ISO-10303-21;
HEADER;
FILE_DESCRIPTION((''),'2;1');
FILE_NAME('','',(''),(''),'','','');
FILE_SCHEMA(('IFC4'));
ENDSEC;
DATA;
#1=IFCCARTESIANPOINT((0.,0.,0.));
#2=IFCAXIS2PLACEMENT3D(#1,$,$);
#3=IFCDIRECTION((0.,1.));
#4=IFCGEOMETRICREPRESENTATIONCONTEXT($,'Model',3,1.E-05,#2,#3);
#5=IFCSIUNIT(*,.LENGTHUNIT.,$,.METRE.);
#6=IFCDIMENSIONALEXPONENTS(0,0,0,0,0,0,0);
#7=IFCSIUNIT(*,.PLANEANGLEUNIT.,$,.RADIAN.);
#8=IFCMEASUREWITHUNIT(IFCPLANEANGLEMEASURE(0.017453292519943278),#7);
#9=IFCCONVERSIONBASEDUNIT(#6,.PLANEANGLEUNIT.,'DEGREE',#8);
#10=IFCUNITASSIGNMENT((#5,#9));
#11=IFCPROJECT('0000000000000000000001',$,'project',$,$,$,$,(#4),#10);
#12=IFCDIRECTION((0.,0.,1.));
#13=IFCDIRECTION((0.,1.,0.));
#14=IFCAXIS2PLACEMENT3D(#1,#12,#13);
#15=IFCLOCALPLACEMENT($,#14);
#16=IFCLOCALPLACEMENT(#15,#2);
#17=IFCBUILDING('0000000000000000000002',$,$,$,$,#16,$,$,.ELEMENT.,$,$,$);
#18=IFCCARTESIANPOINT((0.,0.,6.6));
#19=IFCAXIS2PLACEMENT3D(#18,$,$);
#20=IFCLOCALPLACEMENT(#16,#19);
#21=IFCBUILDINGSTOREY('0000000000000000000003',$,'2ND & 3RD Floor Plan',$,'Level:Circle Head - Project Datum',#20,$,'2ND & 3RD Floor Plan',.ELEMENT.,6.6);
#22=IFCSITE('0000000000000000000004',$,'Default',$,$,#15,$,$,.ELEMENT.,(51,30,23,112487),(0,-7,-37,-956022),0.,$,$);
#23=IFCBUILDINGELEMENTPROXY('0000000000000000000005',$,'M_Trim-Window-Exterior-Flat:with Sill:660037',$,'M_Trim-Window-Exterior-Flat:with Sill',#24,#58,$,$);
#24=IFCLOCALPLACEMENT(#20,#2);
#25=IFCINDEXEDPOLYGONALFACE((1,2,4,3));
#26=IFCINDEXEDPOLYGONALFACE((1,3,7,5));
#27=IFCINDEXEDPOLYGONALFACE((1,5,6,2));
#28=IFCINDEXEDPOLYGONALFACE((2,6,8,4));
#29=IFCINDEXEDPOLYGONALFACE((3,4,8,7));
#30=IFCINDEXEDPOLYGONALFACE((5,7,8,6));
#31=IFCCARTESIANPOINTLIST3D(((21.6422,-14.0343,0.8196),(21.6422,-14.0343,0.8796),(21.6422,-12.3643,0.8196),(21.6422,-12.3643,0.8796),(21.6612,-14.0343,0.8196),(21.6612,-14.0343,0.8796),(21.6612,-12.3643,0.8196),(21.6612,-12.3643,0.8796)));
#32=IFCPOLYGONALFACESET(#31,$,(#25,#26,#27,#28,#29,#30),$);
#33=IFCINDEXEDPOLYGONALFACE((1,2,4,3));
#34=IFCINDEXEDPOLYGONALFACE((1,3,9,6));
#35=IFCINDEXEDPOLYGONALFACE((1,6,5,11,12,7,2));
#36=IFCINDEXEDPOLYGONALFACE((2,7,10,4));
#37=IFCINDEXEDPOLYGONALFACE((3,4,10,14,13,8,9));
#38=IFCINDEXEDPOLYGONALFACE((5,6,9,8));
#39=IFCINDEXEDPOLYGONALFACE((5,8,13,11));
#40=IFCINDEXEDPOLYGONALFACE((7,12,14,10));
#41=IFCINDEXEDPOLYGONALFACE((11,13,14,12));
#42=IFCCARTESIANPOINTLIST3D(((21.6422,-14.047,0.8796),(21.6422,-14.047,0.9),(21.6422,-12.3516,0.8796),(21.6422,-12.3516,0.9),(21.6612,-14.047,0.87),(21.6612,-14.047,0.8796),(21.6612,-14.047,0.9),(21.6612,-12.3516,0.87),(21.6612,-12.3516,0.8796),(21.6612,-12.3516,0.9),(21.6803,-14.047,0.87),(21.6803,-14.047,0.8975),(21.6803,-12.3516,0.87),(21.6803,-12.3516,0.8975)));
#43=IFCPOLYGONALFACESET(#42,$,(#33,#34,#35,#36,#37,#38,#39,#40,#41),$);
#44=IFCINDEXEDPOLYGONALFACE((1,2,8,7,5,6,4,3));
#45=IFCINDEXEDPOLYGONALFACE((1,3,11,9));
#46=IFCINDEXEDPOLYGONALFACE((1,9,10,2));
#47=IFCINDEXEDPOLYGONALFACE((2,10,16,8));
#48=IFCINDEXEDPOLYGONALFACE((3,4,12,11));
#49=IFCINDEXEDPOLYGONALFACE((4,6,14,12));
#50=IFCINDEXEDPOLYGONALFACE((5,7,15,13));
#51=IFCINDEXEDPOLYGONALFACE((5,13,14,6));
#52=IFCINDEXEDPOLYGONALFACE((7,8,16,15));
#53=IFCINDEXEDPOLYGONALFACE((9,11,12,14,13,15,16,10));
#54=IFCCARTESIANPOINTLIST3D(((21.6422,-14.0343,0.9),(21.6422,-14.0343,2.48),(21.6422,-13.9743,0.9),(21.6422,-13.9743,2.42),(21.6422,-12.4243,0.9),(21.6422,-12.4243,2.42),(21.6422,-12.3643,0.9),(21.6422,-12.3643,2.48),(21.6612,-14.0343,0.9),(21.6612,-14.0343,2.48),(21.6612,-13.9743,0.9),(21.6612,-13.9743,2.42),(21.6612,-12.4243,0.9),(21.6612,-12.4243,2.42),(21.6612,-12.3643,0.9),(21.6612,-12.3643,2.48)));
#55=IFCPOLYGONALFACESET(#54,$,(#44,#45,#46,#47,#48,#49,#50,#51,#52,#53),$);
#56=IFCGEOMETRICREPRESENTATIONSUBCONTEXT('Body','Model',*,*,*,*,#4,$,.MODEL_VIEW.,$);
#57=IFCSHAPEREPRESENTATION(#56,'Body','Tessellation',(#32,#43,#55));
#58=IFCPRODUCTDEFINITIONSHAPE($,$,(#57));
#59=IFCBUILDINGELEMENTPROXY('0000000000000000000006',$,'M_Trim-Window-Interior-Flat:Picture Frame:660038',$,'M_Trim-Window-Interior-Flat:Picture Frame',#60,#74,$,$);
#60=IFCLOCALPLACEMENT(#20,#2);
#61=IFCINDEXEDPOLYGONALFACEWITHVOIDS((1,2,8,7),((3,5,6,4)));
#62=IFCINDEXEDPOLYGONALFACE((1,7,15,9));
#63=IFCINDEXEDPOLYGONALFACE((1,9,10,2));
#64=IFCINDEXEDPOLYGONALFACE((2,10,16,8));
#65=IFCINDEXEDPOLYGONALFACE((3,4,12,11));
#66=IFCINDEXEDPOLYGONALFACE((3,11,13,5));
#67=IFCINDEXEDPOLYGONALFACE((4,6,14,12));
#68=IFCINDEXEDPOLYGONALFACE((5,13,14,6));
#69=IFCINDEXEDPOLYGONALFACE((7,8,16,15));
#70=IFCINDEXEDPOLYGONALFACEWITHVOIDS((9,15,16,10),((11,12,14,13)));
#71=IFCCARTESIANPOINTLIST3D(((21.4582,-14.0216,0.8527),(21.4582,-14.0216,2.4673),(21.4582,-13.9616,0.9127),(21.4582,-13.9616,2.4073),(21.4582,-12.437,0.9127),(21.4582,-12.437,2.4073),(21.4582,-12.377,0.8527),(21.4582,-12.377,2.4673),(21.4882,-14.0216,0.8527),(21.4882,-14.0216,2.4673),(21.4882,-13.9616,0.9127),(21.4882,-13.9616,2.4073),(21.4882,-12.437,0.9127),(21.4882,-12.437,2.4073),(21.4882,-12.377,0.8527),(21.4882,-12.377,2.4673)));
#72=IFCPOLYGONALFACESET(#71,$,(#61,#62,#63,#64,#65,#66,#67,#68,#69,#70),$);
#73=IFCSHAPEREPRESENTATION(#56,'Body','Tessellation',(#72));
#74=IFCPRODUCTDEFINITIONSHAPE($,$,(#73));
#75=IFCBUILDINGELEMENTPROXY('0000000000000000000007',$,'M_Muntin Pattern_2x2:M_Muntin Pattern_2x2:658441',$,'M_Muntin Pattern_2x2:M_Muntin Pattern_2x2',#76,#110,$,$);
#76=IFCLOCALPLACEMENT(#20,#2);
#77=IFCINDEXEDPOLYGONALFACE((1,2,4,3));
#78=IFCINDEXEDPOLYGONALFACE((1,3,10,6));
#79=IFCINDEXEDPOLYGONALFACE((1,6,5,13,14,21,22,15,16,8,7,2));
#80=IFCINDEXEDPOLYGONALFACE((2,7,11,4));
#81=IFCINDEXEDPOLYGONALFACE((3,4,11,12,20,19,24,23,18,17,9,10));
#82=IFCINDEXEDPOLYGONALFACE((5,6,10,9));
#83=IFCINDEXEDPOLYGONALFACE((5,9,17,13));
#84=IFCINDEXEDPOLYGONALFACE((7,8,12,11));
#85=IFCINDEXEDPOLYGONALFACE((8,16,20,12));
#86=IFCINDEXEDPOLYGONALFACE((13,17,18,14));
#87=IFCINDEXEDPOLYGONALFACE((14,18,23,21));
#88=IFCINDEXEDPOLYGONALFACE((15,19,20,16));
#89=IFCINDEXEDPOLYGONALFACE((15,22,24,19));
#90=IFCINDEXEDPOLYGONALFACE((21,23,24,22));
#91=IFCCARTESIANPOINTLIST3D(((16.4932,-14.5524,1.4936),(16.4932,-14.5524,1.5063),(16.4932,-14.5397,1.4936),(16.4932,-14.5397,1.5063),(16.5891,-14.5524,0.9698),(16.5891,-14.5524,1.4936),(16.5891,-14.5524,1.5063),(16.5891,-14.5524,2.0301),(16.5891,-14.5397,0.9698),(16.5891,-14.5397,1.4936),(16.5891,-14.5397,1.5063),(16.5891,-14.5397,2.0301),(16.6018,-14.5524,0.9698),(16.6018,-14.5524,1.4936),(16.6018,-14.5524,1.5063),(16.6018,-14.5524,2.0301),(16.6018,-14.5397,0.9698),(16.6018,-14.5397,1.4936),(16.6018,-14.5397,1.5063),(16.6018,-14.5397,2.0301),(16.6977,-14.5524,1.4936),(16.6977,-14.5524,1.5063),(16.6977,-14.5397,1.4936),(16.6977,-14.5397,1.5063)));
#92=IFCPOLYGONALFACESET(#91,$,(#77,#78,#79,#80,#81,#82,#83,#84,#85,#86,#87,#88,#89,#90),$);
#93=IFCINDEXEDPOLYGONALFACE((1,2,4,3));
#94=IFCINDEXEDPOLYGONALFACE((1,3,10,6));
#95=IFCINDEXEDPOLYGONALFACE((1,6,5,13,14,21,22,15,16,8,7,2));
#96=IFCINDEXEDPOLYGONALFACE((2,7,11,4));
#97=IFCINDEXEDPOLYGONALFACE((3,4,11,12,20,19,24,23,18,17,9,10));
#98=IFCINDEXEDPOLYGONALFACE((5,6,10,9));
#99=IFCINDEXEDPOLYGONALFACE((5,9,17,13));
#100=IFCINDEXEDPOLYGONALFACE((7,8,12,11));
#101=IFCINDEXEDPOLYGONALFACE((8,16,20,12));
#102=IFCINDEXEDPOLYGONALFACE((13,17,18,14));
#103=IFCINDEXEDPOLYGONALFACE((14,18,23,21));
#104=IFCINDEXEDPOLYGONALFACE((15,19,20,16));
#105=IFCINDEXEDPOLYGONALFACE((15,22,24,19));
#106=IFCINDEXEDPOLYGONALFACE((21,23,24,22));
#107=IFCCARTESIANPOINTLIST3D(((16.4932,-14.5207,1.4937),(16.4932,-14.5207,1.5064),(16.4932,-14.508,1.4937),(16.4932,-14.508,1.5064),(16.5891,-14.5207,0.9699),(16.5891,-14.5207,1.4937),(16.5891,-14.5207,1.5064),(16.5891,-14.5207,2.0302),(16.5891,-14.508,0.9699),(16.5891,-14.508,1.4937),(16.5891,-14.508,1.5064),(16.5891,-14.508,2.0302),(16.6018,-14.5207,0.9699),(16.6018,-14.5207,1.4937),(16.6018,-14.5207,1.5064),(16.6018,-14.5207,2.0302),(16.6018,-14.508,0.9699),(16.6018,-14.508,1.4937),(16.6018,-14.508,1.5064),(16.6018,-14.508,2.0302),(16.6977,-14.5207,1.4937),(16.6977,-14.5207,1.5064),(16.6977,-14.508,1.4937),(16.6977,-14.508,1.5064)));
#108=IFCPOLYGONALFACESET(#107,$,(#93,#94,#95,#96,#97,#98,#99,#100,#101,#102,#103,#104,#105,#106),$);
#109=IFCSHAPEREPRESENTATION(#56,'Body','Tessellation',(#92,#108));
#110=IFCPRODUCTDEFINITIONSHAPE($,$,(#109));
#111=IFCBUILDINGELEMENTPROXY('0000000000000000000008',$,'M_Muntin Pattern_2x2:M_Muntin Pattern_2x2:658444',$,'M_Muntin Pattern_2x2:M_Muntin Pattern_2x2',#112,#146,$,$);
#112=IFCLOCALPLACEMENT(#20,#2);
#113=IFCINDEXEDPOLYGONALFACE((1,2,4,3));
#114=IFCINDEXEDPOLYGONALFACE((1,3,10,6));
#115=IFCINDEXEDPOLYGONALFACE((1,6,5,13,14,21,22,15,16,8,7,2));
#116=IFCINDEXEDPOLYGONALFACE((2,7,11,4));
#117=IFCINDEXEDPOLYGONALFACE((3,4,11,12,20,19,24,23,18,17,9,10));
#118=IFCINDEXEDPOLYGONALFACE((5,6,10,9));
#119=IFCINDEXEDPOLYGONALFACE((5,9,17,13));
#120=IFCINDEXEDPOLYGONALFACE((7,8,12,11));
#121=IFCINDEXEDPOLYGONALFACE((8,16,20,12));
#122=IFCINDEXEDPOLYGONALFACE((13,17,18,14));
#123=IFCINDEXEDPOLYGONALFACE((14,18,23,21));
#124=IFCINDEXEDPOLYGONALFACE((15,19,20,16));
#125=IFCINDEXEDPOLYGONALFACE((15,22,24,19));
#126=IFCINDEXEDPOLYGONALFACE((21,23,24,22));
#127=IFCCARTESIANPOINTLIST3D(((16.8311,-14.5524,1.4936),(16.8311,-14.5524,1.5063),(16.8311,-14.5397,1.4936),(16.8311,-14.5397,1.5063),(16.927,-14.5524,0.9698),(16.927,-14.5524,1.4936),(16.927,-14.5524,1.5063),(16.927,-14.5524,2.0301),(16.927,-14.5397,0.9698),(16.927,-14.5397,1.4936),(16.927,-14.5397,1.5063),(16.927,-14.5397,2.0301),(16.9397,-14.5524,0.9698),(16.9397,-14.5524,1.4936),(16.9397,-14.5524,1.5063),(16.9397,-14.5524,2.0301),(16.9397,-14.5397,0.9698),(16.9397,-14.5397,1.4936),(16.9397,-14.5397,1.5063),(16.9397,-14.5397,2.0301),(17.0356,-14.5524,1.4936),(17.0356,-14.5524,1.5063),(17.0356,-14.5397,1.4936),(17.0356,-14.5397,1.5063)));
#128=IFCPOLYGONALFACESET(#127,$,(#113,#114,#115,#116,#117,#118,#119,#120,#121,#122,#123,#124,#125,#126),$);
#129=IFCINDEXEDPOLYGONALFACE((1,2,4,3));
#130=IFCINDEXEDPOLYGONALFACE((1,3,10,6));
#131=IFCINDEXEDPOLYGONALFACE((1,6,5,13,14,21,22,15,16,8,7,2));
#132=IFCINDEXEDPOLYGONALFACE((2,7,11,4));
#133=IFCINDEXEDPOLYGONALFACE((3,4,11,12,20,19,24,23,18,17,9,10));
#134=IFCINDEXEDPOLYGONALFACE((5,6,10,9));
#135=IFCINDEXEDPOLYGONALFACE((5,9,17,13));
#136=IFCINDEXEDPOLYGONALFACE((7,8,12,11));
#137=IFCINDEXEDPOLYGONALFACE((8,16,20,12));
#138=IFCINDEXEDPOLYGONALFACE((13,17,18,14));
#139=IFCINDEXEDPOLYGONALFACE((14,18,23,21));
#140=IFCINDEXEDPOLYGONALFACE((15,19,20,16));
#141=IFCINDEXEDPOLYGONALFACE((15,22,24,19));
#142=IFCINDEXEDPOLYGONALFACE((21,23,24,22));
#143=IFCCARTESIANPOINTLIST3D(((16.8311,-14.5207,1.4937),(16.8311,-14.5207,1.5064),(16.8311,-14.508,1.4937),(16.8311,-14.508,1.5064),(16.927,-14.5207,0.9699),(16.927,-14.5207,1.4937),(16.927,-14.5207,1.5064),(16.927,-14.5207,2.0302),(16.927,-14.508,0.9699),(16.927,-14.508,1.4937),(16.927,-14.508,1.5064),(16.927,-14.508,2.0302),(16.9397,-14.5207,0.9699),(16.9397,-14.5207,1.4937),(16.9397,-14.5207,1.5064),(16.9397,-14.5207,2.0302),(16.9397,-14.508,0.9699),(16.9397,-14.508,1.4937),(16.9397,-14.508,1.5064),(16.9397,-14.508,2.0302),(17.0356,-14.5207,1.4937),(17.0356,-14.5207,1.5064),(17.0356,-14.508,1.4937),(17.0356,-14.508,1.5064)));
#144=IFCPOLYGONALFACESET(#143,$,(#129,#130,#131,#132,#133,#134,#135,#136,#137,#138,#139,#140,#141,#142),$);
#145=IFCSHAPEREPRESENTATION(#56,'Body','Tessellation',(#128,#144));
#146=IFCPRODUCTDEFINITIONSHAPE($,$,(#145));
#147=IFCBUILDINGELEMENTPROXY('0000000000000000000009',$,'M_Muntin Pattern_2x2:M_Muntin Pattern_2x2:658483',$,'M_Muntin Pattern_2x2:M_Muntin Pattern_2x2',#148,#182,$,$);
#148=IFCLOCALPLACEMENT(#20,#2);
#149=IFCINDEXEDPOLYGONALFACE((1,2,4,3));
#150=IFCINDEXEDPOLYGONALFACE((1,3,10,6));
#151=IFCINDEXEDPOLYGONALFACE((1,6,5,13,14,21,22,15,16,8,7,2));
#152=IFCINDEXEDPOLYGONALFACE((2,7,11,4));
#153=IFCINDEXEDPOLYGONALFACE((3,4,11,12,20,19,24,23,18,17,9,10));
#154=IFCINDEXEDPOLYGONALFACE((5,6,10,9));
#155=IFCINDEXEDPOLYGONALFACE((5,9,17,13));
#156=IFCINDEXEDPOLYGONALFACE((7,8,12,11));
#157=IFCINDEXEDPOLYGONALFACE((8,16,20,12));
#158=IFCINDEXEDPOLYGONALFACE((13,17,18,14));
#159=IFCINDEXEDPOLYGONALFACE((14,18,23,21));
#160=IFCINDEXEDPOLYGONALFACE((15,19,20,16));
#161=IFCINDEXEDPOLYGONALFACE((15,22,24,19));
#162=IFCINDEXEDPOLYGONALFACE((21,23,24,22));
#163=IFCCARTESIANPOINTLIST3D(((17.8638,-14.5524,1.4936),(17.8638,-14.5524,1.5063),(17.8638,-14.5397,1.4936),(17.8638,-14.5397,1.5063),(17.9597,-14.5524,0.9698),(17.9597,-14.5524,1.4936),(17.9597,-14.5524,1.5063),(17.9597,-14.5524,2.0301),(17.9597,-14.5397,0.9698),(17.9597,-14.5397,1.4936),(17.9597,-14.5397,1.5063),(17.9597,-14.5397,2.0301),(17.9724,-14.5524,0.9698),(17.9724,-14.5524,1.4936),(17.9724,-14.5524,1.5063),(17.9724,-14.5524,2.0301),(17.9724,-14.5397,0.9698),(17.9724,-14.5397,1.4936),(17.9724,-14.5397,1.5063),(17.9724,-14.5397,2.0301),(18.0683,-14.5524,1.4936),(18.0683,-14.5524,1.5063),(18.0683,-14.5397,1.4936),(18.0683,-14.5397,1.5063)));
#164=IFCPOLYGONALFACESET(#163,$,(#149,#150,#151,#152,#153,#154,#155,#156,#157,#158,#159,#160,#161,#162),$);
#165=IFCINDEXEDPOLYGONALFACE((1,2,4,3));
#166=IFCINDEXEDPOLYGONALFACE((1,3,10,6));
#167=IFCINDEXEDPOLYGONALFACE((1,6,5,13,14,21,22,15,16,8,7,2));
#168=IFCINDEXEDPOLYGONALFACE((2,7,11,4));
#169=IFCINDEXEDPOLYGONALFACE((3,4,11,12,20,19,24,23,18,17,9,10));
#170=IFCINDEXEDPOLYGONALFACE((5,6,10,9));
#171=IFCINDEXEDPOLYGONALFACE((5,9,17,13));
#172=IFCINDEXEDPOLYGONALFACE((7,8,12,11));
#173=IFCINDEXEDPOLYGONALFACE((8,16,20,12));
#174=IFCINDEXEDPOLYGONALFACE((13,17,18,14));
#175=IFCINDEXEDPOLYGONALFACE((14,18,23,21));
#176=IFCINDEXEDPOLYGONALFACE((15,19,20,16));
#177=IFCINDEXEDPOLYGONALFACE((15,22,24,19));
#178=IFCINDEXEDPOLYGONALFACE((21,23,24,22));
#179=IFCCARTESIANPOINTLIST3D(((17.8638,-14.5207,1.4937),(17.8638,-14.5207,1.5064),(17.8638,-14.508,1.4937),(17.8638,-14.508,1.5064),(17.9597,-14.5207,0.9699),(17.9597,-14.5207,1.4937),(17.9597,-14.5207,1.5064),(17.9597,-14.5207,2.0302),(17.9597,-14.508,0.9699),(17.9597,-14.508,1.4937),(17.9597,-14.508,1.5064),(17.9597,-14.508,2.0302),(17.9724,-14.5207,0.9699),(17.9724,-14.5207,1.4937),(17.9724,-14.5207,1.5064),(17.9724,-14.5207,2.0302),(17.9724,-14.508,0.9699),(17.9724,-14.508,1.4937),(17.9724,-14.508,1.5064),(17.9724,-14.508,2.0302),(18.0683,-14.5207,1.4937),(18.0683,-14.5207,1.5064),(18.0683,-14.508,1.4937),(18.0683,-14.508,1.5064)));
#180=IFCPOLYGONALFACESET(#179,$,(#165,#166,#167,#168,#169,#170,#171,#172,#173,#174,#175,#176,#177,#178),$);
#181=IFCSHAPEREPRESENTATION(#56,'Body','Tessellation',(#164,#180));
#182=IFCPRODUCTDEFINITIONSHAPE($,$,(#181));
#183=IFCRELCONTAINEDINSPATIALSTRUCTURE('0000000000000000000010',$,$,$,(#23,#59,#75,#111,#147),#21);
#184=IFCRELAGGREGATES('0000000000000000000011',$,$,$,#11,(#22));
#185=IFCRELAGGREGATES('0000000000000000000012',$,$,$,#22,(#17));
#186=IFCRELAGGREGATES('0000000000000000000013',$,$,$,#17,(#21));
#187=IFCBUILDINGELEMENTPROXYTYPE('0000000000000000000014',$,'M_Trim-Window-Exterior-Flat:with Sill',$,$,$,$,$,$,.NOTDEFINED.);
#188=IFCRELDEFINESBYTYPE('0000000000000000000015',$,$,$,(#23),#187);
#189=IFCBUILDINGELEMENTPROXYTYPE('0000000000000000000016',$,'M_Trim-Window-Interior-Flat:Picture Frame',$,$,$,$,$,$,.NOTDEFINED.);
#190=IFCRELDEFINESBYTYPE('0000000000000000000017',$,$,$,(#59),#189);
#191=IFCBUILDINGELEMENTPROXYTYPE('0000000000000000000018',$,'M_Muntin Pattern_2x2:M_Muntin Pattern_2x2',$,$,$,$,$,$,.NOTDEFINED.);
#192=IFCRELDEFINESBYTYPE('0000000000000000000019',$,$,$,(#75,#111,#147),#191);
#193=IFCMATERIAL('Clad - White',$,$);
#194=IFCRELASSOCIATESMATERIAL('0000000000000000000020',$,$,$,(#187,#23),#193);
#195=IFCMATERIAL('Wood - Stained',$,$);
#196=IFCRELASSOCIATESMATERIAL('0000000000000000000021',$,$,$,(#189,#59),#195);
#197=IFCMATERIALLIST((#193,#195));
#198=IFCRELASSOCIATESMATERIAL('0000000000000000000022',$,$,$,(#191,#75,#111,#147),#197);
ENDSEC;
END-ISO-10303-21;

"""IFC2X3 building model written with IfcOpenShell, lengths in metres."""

from ifc_helpers import new_model, entity, si_unit, converted_unit, direction, frame, frame_2d, origin, place, context, subcontext, project, spatial, polyline, rectangle, outline, extrude, source, transform, mapped, material, material_list, type_object, type_shapes, element, save


model = new_model("IFC2X3")

# Units and contexts
model_context = context("Model", 3, precision=1e-05, world=origin(), true_north=direction((0.0, 1.0)))
body_context = subcontext(model_context, "Body", "Model", "MODEL_VIEW")
ifc_project = project(units=[si_unit("LENGTHUNIT", "METRE"), converted_unit("PLANEANGLEUNIT", "DEGREE", entity("IfcPlaneAngleMeasure", 0.017453292519943278), si_unit("PLANEANGLEUNIT", "RADIAN"), dimensions=[0, 0, 0, 0, 0, 0, 0])], contexts=[model_context])

# Site, building, storey
site_placement = place(None, frame((0.0, 0.0, 0.0), z_axis=(0.0, 0.0, 1.0), x_axis=(0.0, 1.0, 0.0)))
site = spatial("IfcSite", under=ifc_project, at=site_placement, Name="Default", CompositionType="ELEMENT", RefLatitude=(51, 30, 23, 112487), RefLongitude=(0, -7, -37, -956022), RefElevation=0.0)
building_placement = place(site_placement, origin())
building = spatial("IfcBuilding", under=site, at=building_placement, CompositionType="ELEMENT")
storey_placement = place(building_placement, frame((0.0, 0.0, 6.6)))
storey = spatial("IfcBuildingStorey", under=building, at=storey_placement, Name="2ND & 3RD Floor Plan", ObjectType="Level:Circle Head - Project Datum", LongName="2ND & 3RD Floor Plan", CompositionType="ELEMENT", Elevation=6.6)

# Building element proxies
ifc_material_1 = material(Name="Clad - White")
ifc_material_2 = material(Name="Wood - Stained")
ifc_material_list = material_list([ifc_material_1, ifc_material_2])
building_element_proxy_type_1 = type_object("IfcBuildingElementProxyType", Name="M_Trim-Window-Exterior-Flat:with Sill", PredefinedType="NOTDEFINED", material=ifc_material_1)
shared_shape_1 = source(origin(), body_context, "Body", "SweptSolid", [
    extrude(rectangle(XDim=1.67, YDim=0.06, at=frame_2d((0.0, 0.0), x_axis=(1.0, 0.0))), frame((0.0, -1.5704, 0.0), z_axis=(0.0, 0.0, 1.0), x_axis=(-1.0, 0.0, 0.0)), (0.0, 0.0, 1.0), 0.019),
    extrude(outline(polyline([(-0.019, -0.0152), (0.0, -0.0152), (0.0, -0.0057), (0.019, -0.0057), (0.019, 0.0148), (0.0, 0.0148), (-0.019, 0.0123), (-0.019, -0.0152)])), frame((-0.8477, -1.5348, 0.019), z_axis=(1.0, 0.0, 0.0), x_axis=(0.0, 0.0, -1.0)), (0.0, 0.0, 1.0), 1.6954),
    extrude(outline(polyline([(-0.805, -0.835), (0.775, -0.835), (0.775, -0.775), (-0.745, -0.775), (-0.745, 0.775), (0.775, 0.775), (0.775, 0.835), (-0.805, 0.835), (-0.805, -0.835)])), frame((0.0, -0.745, 0.0), z_axis=(0.0, 0.0, 1.0), x_axis=(0.0, -1.0, 0.0)), (0.0, 0.0, 1.0), 0.019),
])
type_shapes(building_element_proxy_type_1, [shared_shape_1])
proxy_1_placement = place(storey_placement, frame((21.6422, -13.1993, 2.42), z_axis=(1.0, 0.0, 0.0), x_axis=(0.0, 1.0, 0.0)))
element("IfcBuildingElementProxy", 1, at=proxy_1_placement, inside=storey, type_object=building_element_proxy_type_1, material=ifc_material_1, Name="M_Trim-Window-Exterior-Flat:with Sill:660037", ObjectType="M_Trim-Window-Exterior-Flat:with Sill", context=body_context, shape_type="MappedRepresentation", body=[
    mapped(shared_shape_1, transform((0.0, 0.0, 0.0), scale=1.0)),
])
building_element_proxy_type_2 = type_object("IfcBuildingElementProxyType", Name="M_Trim-Window-Interior-Flat:Picture Frame", PredefinedType="NOTDEFINED", material=ifc_material_2)
shared_shape_2 = source(origin(), body_context, "Body", "SweptSolid", [
    extrude(outline(polyline([(-0.8223, -0.8073), (0.8223, -0.8073), (0.8223, 0.8073), (-0.8223, 0.8073), (-0.8223, -0.8073)]), holes=[polyline([(-0.7623, -0.7473), (-0.7623, 0.7473), (0.7623, 0.7473), (0.7623, -0.7473), (-0.7623, -0.7473)])]), frame((0.0, -0.76, 0.0), z_axis=(0.0, 0.0, 1.0), x_axis=(-1.0, 0.0, 0.0)), (0.0, 0.0, 1.0), 0.03),
])
type_shapes(building_element_proxy_type_2, [shared_shape_2])
proxy_2_placement = place(storey_placement, frame((21.4882, -13.1993, 2.42), z_axis=(-1.0, 0.0, 0.0), x_axis=(0.0, -1.0, 0.0)))
element("IfcBuildingElementProxy", 2, at=proxy_2_placement, inside=storey, type_object=building_element_proxy_type_2, material=ifc_material_2, Name="M_Trim-Window-Interior-Flat:Picture Frame:660038", ObjectType="M_Trim-Window-Interior-Flat:Picture Frame", context=body_context, shape_type="MappedRepresentation", body=[
    mapped(shared_shape_2, transform((0.0, 0.0, 0.0), scale=1.0)),
])
building_element_proxy_type_3 = type_object("IfcBuildingElementProxyType", Name="M_Muntin Pattern_2x2:M_Muntin Pattern_2x2", PredefinedType="NOTDEFINED", material=ifc_material_list)
shared_shape_3 = source(origin(), body_context, "Body", "SweptSolid", [
    extrude(outline(polyline([(0.0064, -0.0064), (0.5301, -0.0064), (0.5301, 0.0063), (0.0064, 0.0063), (0.0064, 0.1023), (-0.0063, 0.1023), (-0.0063, 0.0063), (-0.5302, 0.0063), (-0.5302, -0.0064), (-0.0063, -0.0064), (-0.0063, -0.1023), (0.0064, -0.1023), (0.0064, -0.0064)])), frame((0.0, -0.0222, 0.5301), z_axis=(0.0, 1.0, 0.0), x_axis=(0.0, 0.0, 1.0)), (0.0, 0.0, 1.0), 0.0127),
    extrude(outline(polyline([(0.0064, -0.0064), (0.5302, -0.0064), (0.5302, 0.0063), (0.0064, 0.0063), (0.0064, 0.1023), (-0.0063, 0.1023), (-0.0063, 0.0063), (-0.5302, 0.0063), (-0.5302, -0.0064), (-0.0063, -0.0064), (-0.0063, -0.1023), (0.0064, -0.1023), (0.0064, -0.0064)])), frame((0.0, 0.0095, 0.5302), z_axis=(0.0, 1.0, 0.0), x_axis=(0.0, 0.0, 1.0)), (0.0, 0.0, 1.0), 0.0127),
])
type_shapes(building_element_proxy_type_3, [shared_shape_3])
for number, where, name in (
    (3, (16.5955, -14.5302, 0.9699), "M_Muntin Pattern_2x2:M_Muntin Pattern_2x2:658441"),
    (4, (16.9333, -14.5302, 0.9699), "M_Muntin Pattern_2x2:M_Muntin Pattern_2x2:658444"),
    (5, (17.9661, -14.5302, 0.9699), "M_Muntin Pattern_2x2:M_Muntin Pattern_2x2:658483"),
):
    element("IfcBuildingElementProxy", number, at=place(storey_placement, frame(where)), inside=storey, type_object=building_element_proxy_type_3, material=ifc_material_list, Name=name, ObjectType="M_Muntin Pattern_2x2:M_Muntin Pattern_2x2", context=body_context, shape_type="MappedRepresentation", body=[
        mapped(shared_shape_3, transform((0.0, 0.0, 0.0), scale=1.0)),
    ])

save(model, "model.ifc")
